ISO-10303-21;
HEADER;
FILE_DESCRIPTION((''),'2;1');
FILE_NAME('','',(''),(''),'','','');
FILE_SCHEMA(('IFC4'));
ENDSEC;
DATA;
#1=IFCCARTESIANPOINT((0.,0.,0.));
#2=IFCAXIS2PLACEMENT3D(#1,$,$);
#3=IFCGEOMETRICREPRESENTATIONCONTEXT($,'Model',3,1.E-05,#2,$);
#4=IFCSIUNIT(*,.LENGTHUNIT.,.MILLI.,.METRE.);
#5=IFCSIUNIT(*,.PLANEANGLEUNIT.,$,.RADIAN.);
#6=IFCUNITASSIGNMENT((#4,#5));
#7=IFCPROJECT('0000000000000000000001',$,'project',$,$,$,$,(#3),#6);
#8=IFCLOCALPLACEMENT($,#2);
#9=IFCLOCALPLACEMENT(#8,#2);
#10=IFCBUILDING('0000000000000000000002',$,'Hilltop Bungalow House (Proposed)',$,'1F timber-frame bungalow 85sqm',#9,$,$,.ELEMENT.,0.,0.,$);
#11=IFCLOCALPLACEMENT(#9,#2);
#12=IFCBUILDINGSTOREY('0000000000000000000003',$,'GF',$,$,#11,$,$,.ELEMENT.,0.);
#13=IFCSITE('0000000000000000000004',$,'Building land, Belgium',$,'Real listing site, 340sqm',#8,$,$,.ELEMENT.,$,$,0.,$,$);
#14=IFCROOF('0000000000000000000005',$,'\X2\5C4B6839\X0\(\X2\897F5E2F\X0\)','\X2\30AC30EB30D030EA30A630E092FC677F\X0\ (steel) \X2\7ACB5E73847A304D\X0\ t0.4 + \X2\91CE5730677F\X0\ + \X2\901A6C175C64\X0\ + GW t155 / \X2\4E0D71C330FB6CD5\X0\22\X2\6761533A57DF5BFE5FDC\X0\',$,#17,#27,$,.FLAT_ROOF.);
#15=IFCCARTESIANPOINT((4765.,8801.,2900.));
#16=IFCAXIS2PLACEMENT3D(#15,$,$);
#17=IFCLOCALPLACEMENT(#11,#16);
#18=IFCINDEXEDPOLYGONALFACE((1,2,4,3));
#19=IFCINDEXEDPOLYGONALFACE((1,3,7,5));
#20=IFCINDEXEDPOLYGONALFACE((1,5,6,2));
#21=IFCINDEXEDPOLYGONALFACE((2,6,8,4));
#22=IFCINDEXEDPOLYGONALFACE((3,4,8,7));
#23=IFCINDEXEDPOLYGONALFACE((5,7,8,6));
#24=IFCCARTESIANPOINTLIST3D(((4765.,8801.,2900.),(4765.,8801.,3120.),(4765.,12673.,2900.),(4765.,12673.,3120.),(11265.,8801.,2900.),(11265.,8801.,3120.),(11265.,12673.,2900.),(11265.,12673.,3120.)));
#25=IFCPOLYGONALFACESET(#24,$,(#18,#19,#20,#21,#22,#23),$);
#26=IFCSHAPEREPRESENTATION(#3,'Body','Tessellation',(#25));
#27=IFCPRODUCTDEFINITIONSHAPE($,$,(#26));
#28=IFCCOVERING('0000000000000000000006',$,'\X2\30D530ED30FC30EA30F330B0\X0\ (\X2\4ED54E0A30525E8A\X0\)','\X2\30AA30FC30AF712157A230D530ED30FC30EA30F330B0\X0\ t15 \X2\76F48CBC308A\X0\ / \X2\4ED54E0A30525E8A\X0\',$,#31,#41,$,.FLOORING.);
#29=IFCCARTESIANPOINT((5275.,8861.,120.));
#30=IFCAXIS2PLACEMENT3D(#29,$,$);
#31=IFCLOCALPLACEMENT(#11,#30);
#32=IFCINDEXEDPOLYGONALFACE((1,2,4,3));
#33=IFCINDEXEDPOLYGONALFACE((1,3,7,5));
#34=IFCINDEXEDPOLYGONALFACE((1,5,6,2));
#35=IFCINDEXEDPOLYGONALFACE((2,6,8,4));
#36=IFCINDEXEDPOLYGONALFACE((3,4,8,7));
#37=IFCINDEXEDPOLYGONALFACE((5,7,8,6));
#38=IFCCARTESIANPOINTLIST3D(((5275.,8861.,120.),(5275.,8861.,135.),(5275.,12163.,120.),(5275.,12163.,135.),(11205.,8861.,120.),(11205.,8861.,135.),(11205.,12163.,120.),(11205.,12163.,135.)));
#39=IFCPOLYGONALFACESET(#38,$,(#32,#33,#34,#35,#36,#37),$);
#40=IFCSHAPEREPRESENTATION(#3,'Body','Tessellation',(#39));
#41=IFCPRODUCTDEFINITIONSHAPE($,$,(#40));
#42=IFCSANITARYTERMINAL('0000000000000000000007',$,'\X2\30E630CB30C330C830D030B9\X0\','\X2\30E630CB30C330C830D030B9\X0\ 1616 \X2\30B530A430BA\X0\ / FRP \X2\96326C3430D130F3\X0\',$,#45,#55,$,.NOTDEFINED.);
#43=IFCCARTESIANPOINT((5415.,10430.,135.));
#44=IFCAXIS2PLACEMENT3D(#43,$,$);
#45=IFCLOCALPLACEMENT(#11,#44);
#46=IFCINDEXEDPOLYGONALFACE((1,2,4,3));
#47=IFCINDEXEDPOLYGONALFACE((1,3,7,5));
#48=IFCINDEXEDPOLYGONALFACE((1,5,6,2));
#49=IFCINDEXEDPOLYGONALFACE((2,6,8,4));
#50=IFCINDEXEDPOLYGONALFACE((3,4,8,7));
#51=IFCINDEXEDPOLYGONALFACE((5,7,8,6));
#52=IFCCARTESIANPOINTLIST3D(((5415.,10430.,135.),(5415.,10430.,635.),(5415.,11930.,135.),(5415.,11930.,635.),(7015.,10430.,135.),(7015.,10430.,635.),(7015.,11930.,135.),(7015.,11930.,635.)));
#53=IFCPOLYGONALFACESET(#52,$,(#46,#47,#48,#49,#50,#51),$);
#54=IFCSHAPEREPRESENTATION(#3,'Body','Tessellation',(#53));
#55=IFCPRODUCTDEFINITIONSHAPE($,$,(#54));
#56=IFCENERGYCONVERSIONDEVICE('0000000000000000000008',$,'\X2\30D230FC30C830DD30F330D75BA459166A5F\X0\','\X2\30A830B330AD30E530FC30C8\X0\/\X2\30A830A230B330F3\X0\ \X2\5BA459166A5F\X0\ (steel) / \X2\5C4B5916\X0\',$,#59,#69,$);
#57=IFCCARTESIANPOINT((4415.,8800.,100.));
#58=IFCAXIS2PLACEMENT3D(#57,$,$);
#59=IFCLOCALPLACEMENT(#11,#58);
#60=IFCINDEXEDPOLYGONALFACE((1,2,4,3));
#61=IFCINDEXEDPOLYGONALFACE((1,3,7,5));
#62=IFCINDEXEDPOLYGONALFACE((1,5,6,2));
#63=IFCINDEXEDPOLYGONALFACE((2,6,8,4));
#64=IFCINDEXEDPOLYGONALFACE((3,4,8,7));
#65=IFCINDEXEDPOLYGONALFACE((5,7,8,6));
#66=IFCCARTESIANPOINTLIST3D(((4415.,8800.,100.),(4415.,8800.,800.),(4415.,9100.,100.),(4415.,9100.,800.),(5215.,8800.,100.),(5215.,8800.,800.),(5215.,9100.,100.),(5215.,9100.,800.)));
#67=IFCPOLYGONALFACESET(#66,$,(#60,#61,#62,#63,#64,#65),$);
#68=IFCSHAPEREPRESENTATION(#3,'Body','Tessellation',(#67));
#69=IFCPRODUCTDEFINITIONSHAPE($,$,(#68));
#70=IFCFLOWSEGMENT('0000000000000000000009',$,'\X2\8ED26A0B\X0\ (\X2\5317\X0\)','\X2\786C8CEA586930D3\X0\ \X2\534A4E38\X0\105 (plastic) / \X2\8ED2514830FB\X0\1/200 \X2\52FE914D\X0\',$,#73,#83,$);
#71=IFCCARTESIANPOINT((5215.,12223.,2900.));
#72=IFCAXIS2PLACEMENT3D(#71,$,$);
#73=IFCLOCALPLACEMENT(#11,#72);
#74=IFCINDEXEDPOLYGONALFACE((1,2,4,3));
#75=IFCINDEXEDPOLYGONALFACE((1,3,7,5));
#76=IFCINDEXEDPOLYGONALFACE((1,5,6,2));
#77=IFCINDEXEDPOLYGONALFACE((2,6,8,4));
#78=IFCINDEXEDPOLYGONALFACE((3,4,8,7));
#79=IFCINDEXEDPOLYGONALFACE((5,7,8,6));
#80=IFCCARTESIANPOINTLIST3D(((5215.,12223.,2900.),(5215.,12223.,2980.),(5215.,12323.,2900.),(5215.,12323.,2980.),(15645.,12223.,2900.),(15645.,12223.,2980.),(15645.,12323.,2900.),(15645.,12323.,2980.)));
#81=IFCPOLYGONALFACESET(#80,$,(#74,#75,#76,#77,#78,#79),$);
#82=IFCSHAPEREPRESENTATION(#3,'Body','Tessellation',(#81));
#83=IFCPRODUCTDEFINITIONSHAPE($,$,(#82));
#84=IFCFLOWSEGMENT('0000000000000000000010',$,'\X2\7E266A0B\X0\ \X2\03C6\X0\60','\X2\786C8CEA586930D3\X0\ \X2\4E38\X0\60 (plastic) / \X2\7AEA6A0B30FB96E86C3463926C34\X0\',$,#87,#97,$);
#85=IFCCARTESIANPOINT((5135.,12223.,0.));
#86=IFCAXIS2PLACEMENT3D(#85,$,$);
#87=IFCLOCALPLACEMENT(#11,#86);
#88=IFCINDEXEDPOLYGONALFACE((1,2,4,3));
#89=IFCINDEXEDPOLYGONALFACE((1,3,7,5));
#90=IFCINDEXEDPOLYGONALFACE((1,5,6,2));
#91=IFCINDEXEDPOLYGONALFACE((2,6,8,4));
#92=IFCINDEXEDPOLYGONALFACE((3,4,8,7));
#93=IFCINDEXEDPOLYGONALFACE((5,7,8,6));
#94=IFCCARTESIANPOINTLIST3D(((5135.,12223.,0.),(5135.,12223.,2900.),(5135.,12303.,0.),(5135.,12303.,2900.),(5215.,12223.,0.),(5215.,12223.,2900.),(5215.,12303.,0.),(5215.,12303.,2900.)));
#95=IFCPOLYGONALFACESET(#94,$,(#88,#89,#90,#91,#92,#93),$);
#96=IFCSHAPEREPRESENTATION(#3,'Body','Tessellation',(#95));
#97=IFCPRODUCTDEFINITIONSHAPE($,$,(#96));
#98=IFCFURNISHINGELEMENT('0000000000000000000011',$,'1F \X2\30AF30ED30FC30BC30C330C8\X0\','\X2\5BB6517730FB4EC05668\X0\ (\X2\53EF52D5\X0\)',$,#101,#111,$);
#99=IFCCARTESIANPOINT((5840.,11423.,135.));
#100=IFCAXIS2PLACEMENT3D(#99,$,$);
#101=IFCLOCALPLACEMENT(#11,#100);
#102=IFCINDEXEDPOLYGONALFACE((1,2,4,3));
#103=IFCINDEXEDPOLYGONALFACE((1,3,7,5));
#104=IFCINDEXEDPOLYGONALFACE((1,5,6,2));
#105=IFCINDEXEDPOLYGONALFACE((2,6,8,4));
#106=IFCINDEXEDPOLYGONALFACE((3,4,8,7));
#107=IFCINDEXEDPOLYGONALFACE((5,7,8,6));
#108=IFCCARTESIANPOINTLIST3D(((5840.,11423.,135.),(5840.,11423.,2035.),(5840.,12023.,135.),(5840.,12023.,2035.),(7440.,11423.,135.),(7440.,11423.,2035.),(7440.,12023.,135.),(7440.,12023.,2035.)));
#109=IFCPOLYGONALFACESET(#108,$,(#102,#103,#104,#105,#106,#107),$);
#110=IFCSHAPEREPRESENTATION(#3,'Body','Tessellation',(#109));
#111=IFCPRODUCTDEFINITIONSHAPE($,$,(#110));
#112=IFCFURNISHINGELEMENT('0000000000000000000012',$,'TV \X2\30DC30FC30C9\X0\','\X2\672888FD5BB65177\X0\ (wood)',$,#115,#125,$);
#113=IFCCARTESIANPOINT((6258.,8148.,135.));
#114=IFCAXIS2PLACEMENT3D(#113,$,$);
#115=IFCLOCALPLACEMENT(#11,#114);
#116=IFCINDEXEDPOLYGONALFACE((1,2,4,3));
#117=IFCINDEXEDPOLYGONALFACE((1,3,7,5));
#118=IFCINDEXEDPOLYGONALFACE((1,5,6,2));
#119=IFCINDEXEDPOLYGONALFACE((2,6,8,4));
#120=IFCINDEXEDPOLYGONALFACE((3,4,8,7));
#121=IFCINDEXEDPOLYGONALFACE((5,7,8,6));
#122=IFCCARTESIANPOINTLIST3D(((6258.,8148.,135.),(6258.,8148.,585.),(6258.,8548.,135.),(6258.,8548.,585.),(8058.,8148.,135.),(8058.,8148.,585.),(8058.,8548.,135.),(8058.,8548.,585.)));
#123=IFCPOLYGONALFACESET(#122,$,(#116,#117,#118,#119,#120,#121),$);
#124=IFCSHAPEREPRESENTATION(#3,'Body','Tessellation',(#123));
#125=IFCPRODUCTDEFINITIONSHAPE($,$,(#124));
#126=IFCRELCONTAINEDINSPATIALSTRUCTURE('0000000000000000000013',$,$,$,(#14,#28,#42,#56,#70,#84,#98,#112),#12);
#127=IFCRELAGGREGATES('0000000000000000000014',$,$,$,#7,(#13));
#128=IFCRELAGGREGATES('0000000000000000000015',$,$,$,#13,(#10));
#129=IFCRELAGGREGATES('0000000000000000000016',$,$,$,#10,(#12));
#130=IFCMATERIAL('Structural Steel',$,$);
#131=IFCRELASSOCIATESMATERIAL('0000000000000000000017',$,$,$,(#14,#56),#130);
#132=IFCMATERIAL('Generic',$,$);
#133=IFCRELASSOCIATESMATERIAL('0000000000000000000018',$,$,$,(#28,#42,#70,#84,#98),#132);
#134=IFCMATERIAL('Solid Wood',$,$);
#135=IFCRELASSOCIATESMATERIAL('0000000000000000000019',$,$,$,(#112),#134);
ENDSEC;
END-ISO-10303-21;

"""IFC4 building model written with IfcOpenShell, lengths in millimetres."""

from ifc_helpers import new_model, si_unit, frame, frame_2d, origin, place, context, project, spatial, rectangle, extrude, material, element, save


model = new_model("IFC4")

# Units and contexts
model_context = context("Model", 3, precision=1e-05, world=origin())
ifc_project = project(units=[si_unit("LENGTHUNIT", "METRE", prefix="MILLI"), si_unit("PLANEANGLEUNIT", "RADIAN")], contexts=[model_context])

# Site, building, storey
site_placement = place(None, origin())
site = spatial("IfcSite", under=ifc_project, at=site_placement, Name="Building land, Belgium", ObjectType="Real listing site, 340sqm", CompositionType="ELEMENT", RefElevation=0.0)
building_placement = place(site_placement, origin())
building = spatial("IfcBuilding", under=site, at=building_placement, Name="Hilltop Bungalow House (Proposed)", ObjectType="1F timber-frame bungalow 85sqm", CompositionType="ELEMENT", ElevationOfRefHeight=0.0, ElevationOfTerrain=0.0)
storey_placement = place(building_placement, origin())
storey = spatial("IfcBuildingStorey", under=building, at=storey_placement, Name="GF", CompositionType="ELEMENT", Elevation=0.0)

# Shared definitions
ifc_material_1 = material(Name="Solid Wood")

# Roof
ifc_material_2 = material(Name="Structural Steel")
roof_placement = place(storey_placement, frame((4765.0, 8801.0, 2900.0)))
element("IfcRoof", 1, at=roof_placement, inside=storey, material=ifc_material_2, Name="屋根(西帯)", Description="ガルバリウム鋼板 (steel) 立平葺き t0.4 + 野地板 + 通気層 + GW t155 / 不燃・法22条区域対応", PredefinedType="FLAT_ROOF", context=model_context, shape_type="SweptSolid", body=[
    extrude(rectangle(XDim=6500.0, YDim=3872.0, at=frame_2d((3250.0, 1936.0))), frame((4765.0, 8801.0, 2900.0)), (0.0, 0.0, 1.0), 220.0),
])

# Covering
ifc_material_3 = material(Name="Generic")
covering_placement = place(storey_placement, frame((5275.0, 8861.0, 120.0)))
element("IfcCovering", 2, at=covering_placement, inside=storey, material=ifc_material_3, Name="フローリング (仕上げ床)", Description="オーク無垢フローリング t15 直貼り / 仕上げ床", PredefinedType="FLOORING", context=model_context, shape_type="SweptSolid", body=[
    extrude(rectangle(XDim=5930.0, YDim=3302.0, at=frame_2d((2965.0, 1651.0))), frame((5275.0, 8861.0, 120.0)), (0.0, 0.0, 1.0), 15.0),
])

# Sanitary terminal
sanitary_terminal_placement = place(storey_placement, frame((5415.0, 10430.0, 135.0)))
element("IfcSanitaryTerminal", 3, at=sanitary_terminal_placement, inside=storey, material=ifc_material_3, Name="ユニットバス", Description="ユニットバス 1616 サイズ / FRP 防水パン", PredefinedType="NOTDEFINED", context=model_context, shape_type="SweptSolid", body=[
    extrude(rectangle(XDim=1600.0, YDim=1500.0, at=frame_2d((800.0, 750.0))), frame((5415.0, 10430.0, 135.0)), (0.0, 0.0, 1.0), 500.0),
])

# Energy conversion device
energy_conversion_device_placement = place(storey_placement, frame((4415.0, 8800.0, 100.0)))
element("IfcEnergyConversionDevice", 4, at=energy_conversion_device_placement, inside=storey, material=ifc_material_2, Name="ヒートポンプ室外機", Description="エコキュート/エアコン 室外機 (steel) / 屋外", context=model_context, shape_type="SweptSolid", body=[
    extrude(rectangle(XDim=800.0, YDim=300.0, at=frame_2d((400.0, 150.0))), frame((4415.0, 8800.0, 100.0)), (0.0, 0.0, 1.0), 700.0),
])

# Flow segments
flow_segment_1_placement = place(storey_placement, frame((5215.0, 12223.0, 2900.0)))
element("IfcFlowSegment", 5, at=flow_segment_1_placement, inside=storey, material=ifc_material_3, Name="軒樋 (北)", Description="硬質塩ビ 半丸105 (plastic) / 軒先・1/200 勾配", context=model_context, shape_type="SweptSolid", body=[
    extrude(rectangle(XDim=10430.0, YDim=100.0, at=frame_2d((5215.0, 50.0))), frame((5215.0, 12223.0, 2900.0)), (0.0, 0.0, 1.0), 80.0),
])
flow_segment_2_placement = place(storey_placement, frame((5135.0, 12223.0, 0.0)))
element("IfcFlowSegment", 6, at=flow_segment_2_placement, inside=storey, material=ifc_material_3, Name="縦樋 φ60", Description="硬質塩ビ 丸60 (plastic) / 竪樋・雨水排水", context=model_context, shape_type="SweptSolid", body=[
    extrude(rectangle(XDim=80.0, YDim=80.0, at=frame_2d((40.0, 40.0))), frame((5135.0, 12223.0, 0.0)), (0.0, 0.0, 1.0), 2900.0),
])

# Furnishing elements
furnishing_1_placement = place(storey_placement, frame((5840.0, 11423.0, 135.0)))
element("IfcFurnishingElement", 7, at=furnishing_1_placement, inside=storey, material=ifc_material_3, Name="1F クローゼット", Description="家具・什器 (可動)", context=model_context, shape_type="SweptSolid", body=[
    extrude(rectangle(XDim=1600.0, YDim=600.0, at=frame_2d((800.0, 300.0))), frame((5840.0, 11423.0, 135.0)), (0.0, 0.0, 1.0), 1900.0),
])
furnishing_2_placement = place(storey_placement, frame((6258.0, 8148.0, 135.0)))
element("IfcFurnishingElement", 8, at=furnishing_2_placement, inside=storey, material=ifc_material_1, Name="TV ボード", Description="木製家具 (wood)", context=model_context, shape_type="SweptSolid", body=[
    extrude(rectangle(XDim=1800.0, YDim=400.0, at=frame_2d((900.0, 200.0))), frame((6258.0, 8148.0, 135.0)), (0.0, 0.0, 1.0), 450.0),
])

save(model, "model.ifc")
